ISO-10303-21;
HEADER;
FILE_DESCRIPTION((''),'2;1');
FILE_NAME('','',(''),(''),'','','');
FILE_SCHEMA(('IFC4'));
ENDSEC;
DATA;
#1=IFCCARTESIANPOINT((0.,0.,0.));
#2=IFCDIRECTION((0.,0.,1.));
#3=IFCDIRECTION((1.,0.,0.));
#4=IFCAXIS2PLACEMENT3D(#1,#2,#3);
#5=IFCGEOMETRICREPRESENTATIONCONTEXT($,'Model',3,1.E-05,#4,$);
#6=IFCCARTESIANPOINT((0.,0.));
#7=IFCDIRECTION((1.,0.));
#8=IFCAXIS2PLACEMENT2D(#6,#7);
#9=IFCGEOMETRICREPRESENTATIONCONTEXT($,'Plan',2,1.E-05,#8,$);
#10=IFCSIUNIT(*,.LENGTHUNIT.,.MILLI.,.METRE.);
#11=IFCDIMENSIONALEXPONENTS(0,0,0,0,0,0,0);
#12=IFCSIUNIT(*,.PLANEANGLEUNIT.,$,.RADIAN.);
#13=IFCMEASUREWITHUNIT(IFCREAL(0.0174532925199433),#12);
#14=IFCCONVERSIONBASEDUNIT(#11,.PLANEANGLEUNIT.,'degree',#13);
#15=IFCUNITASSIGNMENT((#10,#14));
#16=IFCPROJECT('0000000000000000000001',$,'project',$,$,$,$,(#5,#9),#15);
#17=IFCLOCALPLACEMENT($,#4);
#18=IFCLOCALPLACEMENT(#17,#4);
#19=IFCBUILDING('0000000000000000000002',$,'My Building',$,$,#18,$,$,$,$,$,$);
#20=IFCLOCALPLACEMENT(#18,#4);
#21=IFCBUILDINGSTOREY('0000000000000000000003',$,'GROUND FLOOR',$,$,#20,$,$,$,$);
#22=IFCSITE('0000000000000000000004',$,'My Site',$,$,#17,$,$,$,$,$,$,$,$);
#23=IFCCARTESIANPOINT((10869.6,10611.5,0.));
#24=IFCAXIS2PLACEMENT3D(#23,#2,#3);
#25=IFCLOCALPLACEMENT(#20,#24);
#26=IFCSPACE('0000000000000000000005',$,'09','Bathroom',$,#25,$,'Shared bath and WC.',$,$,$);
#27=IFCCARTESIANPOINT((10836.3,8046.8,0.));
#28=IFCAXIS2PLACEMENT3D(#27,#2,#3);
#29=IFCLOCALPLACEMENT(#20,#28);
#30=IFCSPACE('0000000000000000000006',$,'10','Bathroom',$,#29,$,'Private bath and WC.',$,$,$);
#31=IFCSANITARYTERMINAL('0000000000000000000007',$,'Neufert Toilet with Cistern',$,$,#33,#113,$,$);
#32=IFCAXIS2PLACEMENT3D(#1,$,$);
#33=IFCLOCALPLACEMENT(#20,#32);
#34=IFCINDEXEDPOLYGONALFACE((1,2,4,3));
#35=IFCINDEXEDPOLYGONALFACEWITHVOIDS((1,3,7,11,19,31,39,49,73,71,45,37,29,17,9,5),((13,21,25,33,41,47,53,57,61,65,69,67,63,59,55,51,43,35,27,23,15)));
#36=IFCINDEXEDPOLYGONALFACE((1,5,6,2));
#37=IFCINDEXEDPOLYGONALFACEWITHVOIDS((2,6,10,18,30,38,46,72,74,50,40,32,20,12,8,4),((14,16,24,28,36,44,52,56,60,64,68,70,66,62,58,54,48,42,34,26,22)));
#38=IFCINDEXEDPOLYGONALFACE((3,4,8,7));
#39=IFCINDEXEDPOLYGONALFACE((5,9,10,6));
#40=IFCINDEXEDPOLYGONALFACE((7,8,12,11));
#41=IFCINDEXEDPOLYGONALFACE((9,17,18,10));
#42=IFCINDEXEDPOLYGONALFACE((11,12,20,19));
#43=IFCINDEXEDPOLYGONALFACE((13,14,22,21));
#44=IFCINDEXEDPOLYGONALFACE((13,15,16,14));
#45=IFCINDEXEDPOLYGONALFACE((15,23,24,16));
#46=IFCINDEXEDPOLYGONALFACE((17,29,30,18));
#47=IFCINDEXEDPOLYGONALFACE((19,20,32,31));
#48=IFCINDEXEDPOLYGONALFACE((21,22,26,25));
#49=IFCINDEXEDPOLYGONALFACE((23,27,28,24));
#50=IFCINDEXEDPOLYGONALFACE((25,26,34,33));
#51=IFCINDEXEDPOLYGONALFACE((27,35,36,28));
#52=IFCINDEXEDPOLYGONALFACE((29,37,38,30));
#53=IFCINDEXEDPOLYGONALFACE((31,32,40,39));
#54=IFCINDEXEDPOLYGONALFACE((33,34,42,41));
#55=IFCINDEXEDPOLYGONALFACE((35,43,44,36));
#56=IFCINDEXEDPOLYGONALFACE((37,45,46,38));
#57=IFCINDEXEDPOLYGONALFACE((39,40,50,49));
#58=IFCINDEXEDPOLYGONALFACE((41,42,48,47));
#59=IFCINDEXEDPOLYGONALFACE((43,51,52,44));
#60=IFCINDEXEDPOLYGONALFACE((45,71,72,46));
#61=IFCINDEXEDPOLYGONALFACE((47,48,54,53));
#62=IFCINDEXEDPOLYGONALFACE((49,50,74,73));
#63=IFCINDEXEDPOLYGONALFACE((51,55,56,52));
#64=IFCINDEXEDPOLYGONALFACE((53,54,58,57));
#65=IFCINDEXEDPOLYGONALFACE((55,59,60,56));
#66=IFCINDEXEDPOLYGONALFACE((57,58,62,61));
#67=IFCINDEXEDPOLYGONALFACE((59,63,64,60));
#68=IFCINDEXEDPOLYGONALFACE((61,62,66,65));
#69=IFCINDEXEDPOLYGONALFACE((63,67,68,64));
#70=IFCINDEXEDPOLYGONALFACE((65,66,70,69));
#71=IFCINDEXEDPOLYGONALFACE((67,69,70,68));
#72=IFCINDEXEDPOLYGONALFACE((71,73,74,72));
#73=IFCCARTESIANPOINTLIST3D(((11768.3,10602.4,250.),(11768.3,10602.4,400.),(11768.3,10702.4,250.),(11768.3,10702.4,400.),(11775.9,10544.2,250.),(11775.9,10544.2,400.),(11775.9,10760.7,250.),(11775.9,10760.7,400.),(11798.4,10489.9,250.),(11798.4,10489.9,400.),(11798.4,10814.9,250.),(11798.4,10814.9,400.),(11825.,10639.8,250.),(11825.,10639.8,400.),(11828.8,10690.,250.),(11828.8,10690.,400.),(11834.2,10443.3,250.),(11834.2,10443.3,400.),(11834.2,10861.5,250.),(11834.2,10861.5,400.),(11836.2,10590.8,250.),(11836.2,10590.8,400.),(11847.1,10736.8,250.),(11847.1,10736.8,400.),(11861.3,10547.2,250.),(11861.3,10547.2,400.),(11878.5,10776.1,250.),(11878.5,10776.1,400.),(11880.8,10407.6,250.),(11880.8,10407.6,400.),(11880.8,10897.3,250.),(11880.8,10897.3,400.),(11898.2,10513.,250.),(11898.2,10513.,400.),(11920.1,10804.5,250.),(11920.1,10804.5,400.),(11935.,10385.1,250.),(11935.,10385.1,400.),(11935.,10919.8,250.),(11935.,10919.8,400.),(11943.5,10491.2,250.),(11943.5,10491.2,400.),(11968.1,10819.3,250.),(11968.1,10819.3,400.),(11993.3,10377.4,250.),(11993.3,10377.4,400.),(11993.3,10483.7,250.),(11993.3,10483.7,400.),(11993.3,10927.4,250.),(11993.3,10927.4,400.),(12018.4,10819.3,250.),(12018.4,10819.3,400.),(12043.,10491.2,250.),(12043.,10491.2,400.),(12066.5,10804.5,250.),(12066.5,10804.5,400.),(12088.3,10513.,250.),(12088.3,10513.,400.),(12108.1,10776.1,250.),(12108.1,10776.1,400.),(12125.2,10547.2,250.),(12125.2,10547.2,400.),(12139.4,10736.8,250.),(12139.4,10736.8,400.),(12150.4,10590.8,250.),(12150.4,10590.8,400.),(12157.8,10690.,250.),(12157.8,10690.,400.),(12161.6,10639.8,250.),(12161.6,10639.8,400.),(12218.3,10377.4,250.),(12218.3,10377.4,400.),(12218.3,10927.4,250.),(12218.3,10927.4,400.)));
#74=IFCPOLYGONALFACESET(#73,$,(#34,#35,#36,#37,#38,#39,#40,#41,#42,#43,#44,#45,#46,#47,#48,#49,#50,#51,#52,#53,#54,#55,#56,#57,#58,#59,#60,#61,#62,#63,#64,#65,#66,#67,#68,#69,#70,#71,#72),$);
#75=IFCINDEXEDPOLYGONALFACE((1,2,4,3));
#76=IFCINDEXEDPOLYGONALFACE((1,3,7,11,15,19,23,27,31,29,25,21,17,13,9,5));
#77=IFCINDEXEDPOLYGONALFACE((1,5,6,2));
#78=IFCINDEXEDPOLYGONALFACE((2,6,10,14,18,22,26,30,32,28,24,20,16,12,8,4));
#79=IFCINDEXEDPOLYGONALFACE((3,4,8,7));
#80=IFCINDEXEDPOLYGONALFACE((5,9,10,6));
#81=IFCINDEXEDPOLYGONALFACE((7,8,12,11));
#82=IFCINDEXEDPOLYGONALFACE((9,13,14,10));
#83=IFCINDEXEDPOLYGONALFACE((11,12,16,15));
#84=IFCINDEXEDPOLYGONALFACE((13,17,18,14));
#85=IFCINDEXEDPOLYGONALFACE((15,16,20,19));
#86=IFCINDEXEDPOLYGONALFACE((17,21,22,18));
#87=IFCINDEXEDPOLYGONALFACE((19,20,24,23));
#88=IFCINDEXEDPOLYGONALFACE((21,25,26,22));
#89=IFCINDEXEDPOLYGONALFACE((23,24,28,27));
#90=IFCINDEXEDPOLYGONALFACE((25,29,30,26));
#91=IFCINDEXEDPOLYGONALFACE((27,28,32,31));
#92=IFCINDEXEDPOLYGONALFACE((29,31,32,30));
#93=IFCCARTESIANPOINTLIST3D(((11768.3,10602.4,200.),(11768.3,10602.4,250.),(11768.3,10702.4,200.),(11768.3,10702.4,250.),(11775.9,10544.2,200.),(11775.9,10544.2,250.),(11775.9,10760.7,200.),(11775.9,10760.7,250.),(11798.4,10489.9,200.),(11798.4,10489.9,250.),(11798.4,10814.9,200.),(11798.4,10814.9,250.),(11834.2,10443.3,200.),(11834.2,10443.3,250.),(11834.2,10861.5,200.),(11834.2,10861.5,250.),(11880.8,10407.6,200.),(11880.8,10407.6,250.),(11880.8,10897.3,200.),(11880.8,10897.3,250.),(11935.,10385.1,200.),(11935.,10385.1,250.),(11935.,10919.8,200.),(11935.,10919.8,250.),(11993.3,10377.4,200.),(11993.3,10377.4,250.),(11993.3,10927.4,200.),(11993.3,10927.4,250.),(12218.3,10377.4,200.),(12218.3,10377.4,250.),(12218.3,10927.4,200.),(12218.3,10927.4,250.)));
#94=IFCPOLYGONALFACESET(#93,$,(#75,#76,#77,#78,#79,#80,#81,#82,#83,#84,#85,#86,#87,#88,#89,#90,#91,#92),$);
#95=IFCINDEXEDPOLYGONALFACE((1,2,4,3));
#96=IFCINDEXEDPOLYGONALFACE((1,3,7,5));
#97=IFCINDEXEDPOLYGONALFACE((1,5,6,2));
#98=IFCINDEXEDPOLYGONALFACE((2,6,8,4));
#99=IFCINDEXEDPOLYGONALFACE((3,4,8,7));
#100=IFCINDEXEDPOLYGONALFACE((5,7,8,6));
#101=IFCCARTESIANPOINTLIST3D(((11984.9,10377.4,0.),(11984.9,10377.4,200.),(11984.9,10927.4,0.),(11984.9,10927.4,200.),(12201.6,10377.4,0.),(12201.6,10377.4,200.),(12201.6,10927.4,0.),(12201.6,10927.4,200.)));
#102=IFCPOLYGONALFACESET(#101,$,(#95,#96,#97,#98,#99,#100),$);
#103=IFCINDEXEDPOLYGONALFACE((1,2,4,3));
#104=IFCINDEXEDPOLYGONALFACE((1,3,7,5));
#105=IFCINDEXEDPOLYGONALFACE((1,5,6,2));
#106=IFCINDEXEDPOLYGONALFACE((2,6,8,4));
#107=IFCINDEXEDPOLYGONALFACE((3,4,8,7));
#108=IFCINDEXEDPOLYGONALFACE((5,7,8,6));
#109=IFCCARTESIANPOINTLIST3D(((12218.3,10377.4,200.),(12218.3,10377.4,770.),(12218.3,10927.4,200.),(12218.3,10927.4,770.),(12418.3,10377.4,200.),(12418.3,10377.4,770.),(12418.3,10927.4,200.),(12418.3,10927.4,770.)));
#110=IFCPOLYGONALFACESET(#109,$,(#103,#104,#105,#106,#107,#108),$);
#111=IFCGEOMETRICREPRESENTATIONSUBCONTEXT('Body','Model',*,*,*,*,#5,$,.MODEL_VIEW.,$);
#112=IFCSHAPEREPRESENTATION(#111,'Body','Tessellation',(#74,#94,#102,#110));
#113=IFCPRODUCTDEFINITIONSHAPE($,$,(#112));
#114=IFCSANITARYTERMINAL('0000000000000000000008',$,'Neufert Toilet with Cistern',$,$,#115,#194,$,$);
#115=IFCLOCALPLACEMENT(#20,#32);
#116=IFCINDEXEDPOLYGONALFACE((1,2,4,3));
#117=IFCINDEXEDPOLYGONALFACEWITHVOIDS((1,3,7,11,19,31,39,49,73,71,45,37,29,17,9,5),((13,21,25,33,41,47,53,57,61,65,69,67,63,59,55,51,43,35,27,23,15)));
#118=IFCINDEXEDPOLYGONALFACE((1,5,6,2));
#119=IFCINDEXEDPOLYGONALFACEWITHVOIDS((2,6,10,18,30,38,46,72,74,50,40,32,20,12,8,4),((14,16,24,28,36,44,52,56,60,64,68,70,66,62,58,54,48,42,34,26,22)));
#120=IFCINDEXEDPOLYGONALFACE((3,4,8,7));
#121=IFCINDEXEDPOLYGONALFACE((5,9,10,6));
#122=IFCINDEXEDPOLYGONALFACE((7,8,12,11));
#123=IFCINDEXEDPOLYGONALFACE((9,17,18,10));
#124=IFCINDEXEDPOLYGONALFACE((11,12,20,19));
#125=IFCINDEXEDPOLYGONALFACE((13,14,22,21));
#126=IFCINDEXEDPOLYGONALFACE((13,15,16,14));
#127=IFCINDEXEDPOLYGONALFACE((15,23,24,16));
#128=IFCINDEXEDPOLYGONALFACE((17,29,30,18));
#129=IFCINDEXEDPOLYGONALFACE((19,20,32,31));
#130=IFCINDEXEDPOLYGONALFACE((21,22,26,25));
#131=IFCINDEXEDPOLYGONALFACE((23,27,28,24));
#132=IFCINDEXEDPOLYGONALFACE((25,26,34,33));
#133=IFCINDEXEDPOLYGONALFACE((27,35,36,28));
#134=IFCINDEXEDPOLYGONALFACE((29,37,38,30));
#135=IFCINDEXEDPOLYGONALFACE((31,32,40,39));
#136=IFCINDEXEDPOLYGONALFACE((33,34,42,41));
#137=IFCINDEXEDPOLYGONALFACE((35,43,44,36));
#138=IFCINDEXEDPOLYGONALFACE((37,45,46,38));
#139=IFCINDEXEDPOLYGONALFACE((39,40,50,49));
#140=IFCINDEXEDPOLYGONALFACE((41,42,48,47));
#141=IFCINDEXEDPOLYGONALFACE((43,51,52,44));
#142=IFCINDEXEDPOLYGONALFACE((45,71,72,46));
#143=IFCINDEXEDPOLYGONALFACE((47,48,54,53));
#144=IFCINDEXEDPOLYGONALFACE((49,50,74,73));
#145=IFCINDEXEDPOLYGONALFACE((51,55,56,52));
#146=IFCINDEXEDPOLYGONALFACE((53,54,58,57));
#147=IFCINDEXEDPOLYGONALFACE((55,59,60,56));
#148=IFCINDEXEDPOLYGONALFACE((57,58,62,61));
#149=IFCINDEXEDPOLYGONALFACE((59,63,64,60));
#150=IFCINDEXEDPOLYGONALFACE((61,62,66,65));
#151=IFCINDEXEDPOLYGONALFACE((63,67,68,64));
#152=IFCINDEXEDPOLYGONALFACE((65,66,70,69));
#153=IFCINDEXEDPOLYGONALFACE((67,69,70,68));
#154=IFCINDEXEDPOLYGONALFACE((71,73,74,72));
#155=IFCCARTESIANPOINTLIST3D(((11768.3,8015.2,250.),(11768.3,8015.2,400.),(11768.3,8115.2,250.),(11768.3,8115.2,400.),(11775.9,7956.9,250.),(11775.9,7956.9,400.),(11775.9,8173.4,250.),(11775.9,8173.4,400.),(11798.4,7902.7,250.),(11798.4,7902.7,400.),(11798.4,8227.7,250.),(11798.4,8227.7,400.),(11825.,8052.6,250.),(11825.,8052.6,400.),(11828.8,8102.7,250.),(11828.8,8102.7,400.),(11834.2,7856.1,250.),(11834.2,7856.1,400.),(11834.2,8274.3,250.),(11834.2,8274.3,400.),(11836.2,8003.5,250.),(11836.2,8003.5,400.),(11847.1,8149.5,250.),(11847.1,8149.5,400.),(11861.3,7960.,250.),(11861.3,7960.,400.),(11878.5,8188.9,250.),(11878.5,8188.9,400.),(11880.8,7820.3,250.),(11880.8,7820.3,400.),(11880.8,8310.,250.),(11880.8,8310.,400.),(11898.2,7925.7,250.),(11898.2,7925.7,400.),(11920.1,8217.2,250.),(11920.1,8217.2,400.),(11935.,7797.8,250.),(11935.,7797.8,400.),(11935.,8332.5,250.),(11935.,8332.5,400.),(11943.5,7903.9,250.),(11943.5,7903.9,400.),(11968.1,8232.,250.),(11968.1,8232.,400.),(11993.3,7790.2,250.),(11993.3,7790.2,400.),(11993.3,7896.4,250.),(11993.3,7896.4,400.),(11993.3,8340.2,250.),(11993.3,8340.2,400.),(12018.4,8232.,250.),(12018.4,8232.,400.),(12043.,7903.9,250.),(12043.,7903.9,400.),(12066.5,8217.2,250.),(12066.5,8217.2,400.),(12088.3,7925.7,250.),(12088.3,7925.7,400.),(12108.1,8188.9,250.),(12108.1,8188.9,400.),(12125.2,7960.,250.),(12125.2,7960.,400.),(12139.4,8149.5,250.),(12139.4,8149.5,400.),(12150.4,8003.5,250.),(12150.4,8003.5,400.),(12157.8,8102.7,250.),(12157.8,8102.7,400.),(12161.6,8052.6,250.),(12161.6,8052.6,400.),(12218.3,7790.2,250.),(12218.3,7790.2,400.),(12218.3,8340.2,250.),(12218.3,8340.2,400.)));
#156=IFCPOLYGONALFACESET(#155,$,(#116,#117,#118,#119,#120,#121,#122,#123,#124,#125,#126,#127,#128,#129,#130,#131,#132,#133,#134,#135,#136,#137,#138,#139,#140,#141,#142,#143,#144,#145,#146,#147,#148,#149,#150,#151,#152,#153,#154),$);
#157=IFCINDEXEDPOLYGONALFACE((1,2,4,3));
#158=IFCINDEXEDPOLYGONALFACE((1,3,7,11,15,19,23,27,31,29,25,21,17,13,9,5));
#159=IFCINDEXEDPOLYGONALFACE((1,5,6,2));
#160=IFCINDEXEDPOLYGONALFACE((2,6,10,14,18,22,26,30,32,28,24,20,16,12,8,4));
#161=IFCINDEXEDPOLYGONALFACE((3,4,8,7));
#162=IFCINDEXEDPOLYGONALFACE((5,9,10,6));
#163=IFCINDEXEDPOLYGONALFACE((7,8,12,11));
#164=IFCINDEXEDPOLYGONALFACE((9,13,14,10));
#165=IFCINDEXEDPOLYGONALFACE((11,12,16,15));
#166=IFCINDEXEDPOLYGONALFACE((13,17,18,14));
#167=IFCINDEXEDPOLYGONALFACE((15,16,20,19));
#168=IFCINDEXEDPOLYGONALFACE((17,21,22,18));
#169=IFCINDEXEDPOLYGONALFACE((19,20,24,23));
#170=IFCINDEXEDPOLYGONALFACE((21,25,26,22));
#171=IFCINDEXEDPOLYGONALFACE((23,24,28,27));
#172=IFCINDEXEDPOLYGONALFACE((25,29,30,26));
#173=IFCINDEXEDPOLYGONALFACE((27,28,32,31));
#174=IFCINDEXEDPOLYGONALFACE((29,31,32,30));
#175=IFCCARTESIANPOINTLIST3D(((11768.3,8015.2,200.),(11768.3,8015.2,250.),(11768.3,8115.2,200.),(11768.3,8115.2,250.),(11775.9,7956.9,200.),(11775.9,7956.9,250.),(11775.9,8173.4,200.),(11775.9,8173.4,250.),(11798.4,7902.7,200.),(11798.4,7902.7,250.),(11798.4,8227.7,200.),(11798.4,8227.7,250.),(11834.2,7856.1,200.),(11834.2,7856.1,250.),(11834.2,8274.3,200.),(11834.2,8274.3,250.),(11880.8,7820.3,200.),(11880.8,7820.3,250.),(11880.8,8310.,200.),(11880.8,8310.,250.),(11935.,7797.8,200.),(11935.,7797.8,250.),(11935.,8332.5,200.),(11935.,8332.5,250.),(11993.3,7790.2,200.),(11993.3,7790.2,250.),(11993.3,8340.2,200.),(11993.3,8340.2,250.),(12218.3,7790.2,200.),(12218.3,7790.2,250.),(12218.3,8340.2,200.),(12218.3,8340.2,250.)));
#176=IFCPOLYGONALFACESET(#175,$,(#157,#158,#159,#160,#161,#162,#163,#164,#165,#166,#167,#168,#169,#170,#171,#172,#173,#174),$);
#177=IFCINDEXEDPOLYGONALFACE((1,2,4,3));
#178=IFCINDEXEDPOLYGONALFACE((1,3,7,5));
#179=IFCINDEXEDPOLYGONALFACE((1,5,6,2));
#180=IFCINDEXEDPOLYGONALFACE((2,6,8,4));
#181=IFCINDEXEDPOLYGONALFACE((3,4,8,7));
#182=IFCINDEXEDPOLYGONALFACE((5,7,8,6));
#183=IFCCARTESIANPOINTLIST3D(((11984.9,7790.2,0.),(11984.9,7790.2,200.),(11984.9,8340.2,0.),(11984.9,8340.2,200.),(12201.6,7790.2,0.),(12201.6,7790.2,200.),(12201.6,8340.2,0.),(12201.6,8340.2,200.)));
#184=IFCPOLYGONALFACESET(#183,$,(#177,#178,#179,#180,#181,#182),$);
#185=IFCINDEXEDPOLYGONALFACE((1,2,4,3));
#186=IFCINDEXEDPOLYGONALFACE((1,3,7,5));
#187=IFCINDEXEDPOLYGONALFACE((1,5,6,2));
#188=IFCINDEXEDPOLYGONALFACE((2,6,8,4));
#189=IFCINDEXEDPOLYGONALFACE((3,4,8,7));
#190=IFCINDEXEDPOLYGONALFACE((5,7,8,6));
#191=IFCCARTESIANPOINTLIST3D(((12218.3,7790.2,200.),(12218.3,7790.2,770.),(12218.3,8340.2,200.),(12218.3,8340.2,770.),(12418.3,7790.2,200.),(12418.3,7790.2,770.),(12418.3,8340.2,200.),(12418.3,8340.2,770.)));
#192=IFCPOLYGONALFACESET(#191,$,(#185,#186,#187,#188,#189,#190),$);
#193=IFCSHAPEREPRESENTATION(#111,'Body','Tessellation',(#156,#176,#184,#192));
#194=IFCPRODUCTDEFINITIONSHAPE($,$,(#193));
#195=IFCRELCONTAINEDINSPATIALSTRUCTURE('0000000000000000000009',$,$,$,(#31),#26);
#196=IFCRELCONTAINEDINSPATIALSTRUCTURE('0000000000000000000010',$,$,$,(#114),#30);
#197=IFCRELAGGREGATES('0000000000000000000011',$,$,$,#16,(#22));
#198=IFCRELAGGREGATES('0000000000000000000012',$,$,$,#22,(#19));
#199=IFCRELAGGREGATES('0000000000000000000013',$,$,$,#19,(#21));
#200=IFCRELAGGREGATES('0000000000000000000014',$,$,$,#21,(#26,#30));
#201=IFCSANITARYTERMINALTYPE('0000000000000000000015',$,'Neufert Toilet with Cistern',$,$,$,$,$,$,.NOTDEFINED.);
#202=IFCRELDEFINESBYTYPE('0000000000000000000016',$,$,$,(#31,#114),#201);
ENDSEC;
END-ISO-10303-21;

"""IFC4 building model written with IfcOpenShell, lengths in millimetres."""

from ifc_helpers import new_model, entity, si_unit, converted_unit, frame, frame_2d, origin_with_axes, origin_2d_with_axis, place, context, subcontext, project, spatial, line, arc, indexed_curve, circle_curve, outline, extrude, shape, source, transform, mapped, type_object, type_shapes, element, save


model = new_model("IFC4")

# Units and contexts
model_context = context("Model", 3, precision=1e-05, world=origin_with_axes())
plan_context = context("Plan", 2, precision=1e-05, world=origin_2d_with_axis())
body_context_1 = subcontext(model_context, "Body", "Model", "MODEL_VIEW")
body_context_2 = subcontext(plan_context, "Body", "Plan", "PLAN_VIEW")
ifc_project = project(units=[si_unit("LENGTHUNIT", "METRE", prefix="MILLI"), converted_unit("PLANEANGLEUNIT", "degree", entity("IfcReal", 0.0174532925199433), si_unit("PLANEANGLEUNIT", "RADIAN"), dimensions=[0, 0, 0, 0, 0, 0, 0])], contexts=[model_context, plan_context])

# Site, building, storey
site_placement = place(None, origin_with_axes())
site = spatial("IfcSite", under=ifc_project, at=site_placement, Name="My Site")
building_placement = place(site_placement, origin_with_axes())
building = spatial("IfcBuilding", under=site, at=building_placement, Name="My Building")
storey_placement = place(building_placement, origin_with_axes())
storey = spatial("IfcBuildingStorey", under=building, at=storey_placement, Name="GROUND FLOOR")

# Shared definitions
space_1_placement = place(storey_placement, frame((10869.6, 10611.5, 0.0), z_axis=(0.0, 0.0, 1.0), x_axis=(1.0, 0.0, 0.0)))
space_1 = spatial("IfcSpace", under=storey, at=space_1_placement, Name="09", Description="Bathroom", LongName="Shared bath and WC.")

# Sanitary terminal
sanitary_terminal_type_1 = type_object("IfcSanitaryTerminalType", Name="Neufert Toilet with Cistern", PredefinedType="NOTDEFINED")
shared_shape_1 = source(origin_with_axes(), body_context_1, "Body", "SweptSolid", [
    extrude(outline(indexed_curve([(-275.0, -200.0), (275.0, -200.0), (275.0, -425.0), (209.1, -584.1), (50.0, -650.0), (-50.0, -650.0), (-209.1, -584.1), (-275.0, -425.0)], segments=[line(1, 2), line(2, 3), arc(3, 4, 5), line(5, 6), arc(6, 7, 8), line(8, 1)]), holes=[circle_curve(frame_2d((0.0, -425.0)), 168.8)]), frame((0.0, 0.0, 250.0), z_axis=(0.0, 0.0, 1.0), x_axis=(1.0, 0.0, 0.0)), (0.0, 0.0, 1.0), 150.0),
    extrude(outline(indexed_curve([(-275.0, -200.0), (275.0, -200.0), (275.0, -425.0), (209.1, -584.1), (50.0, -650.0), (-50.0, -650.0), (-209.1, -584.1), (-275.0, -425.0)], segments=[line(1, 2), line(2, 3), arc(3, 4, 5), line(5, 6), arc(6, 7, 8), line(8, 1)])), frame((0.0, 0.0, 200.0), z_axis=(0.0, 0.0, 1.0), x_axis=(1.0, 0.0, 0.0)), (0.0, 0.0, 1.0), 50.0),
    extrude(outline(indexed_curve([(-275.0, -216.7), (275.0, -216.7), (275.0, -433.3), (-275.0, -433.3)], segments=[line(1, 2, 3, 4, 1)])), origin_with_axes(), (0.0, 0.0, 1.0), 200.0),
    extrude(outline(indexed_curve([(-275.0, 0.0), (275.0, 0.0), (275.0, -200.0), (-275.0, -200.0)], segments=[line(1, 2, 3, 4, 1)])), frame((0.0, 0.0, 200.0), z_axis=(0.0, 0.0, 1.0), x_axis=(1.0, 0.0, 0.0)), (0.0, 0.0, 1.0), 570.0),
])
shared_shape_2 = source(origin_with_axes(), body_context_2, "Body", "Curve2D", [
    entity("IfcIndexedPolyCurve", entity("IfcCartesianPointList2D", [[-275.0, 0.0], [275.0, 0.0], [275.0, -200.0], [-275.0, -200.0]]), [entity("IfcLineIndex", [1, 2, 3, 4, 1])]),
    entity("IfcIndexedPolyCurve", entity("IfcCartesianPointList2D", [[165.0, -200.0], [192.5, -335.0]])),
    entity("IfcTrimmedCurve", entity("IfcEllipse", entity("IfcAxis2Placement2D", entity("IfcCartesianPoint", [0.0, -335.0]), entity("IfcDirection", [1.0, 0.0])), 192.5, 315.0), [entity("IfcCartesianPoint", [-192.5, -335.0])], [entity("IfcCartesianPoint", [192.5, -335.0])], True, "CARTESIAN"),
    entity("IfcIndexedPolyCurve", entity("IfcCartesianPointList2D", [[-165.0, -200.0], [-192.5, -335.0]])),
    entity("IfcEllipse", entity("IfcAxis2Placement2D", entity("IfcCartesianPoint", [0.0, -452.0]), entity("IfcDirection", [1.0, 0.0])), 131.2, 157.5),
    entity("IfcIndexedPolyCurve", entity("IfcCartesianPointList2D", [[-34.4, -452.0], [-34.4, -429.5], [34.4, -429.5], [34.4, -452.0]])),
    entity("IfcTrimmedCurve", entity("IfcEllipse", entity("IfcAxis2Placement2D", entity("IfcCartesianPoint", [0.0, -452.0]), entity("IfcDirection", [1.0, 0.0])), 34.4, 22.5), [entity("IfcCartesianPoint", [-34.4, -452.0])], [entity("IfcCartesianPoint", [34.4, -452.0])], True, "CARTESIAN"),
])
type_shapes(sanitary_terminal_type_1, [shared_shape_1, shared_shape_2])
sanitary_terminal_1_placement = place(space_1_placement, frame((1548.7, 40.9, 0.0), z_axis=(0.0, 0.0, 1.0), x_axis=(0.0, -1.0, 0.0)))
element("IfcSanitaryTerminal", 1, at=sanitary_terminal_1_placement, inside=space_1, type_object=sanitary_terminal_type_1, Name="Neufert Toilet with Cistern", shapes=[
    shape(body_context_1, "Body", "MappedRepresentation", [mapped(shared_shape_1, transform((0.0, 0.0, 0.0), x_axis=(1.0, 0.0, 0.0), y_axis=(0.0, 1.0, 0.0), z_axis=(0.0, 0.0, 1.0), scale=1.0))]),
    shape(body_context_2, "Body", "MappedRepresentation", [mapped(shared_shape_2, transform((0.0, 0.0, 0.0), x_axis=(1.0, 0.0, 0.0), y_axis=(0.0, 1.0, 0.0), z_axis=(0.0, 0.0, 1.0), scale=1.0))]),
])

# Shared definitions
space_2_placement = place(storey_placement, frame((10836.3, 8046.8, 0.0), z_axis=(0.0, 0.0, 1.0), x_axis=(1.0, 0.0, 0.0)))
space_2 = spatial("IfcSpace", under=storey, at=space_2_placement, Name="10", Description="Bathroom", LongName="Private bath and WC.")

# Sanitary terminal
sanitary_terminal_2_placement = place(space_2_placement, frame((1582.0, 18.4, 0.0), z_axis=(0.0, 0.0, 1.0), x_axis=(0.0, -1.0, 0.0)))
element("IfcSanitaryTerminal", 2, at=sanitary_terminal_2_placement, inside=space_2, type_object=sanitary_terminal_type_1, Name="Neufert Toilet with Cistern", shapes=[
    shape(body_context_1, "Body", "MappedRepresentation", [mapped(shared_shape_1, transform((0.0, 0.0, 0.0), x_axis=(1.0, 0.0, 0.0), y_axis=(0.0, 1.0, 0.0), z_axis=(0.0, 0.0, 1.0), scale=1.0))]),
    shape(body_context_2, "Body", "MappedRepresentation", [mapped(shared_shape_2, transform((0.0, 0.0, 0.0), x_axis=(1.0, 0.0, 0.0), y_axis=(0.0, 1.0, 0.0), z_axis=(0.0, 0.0, 1.0), scale=1.0))]),
])

save(model, "model.ifc")
